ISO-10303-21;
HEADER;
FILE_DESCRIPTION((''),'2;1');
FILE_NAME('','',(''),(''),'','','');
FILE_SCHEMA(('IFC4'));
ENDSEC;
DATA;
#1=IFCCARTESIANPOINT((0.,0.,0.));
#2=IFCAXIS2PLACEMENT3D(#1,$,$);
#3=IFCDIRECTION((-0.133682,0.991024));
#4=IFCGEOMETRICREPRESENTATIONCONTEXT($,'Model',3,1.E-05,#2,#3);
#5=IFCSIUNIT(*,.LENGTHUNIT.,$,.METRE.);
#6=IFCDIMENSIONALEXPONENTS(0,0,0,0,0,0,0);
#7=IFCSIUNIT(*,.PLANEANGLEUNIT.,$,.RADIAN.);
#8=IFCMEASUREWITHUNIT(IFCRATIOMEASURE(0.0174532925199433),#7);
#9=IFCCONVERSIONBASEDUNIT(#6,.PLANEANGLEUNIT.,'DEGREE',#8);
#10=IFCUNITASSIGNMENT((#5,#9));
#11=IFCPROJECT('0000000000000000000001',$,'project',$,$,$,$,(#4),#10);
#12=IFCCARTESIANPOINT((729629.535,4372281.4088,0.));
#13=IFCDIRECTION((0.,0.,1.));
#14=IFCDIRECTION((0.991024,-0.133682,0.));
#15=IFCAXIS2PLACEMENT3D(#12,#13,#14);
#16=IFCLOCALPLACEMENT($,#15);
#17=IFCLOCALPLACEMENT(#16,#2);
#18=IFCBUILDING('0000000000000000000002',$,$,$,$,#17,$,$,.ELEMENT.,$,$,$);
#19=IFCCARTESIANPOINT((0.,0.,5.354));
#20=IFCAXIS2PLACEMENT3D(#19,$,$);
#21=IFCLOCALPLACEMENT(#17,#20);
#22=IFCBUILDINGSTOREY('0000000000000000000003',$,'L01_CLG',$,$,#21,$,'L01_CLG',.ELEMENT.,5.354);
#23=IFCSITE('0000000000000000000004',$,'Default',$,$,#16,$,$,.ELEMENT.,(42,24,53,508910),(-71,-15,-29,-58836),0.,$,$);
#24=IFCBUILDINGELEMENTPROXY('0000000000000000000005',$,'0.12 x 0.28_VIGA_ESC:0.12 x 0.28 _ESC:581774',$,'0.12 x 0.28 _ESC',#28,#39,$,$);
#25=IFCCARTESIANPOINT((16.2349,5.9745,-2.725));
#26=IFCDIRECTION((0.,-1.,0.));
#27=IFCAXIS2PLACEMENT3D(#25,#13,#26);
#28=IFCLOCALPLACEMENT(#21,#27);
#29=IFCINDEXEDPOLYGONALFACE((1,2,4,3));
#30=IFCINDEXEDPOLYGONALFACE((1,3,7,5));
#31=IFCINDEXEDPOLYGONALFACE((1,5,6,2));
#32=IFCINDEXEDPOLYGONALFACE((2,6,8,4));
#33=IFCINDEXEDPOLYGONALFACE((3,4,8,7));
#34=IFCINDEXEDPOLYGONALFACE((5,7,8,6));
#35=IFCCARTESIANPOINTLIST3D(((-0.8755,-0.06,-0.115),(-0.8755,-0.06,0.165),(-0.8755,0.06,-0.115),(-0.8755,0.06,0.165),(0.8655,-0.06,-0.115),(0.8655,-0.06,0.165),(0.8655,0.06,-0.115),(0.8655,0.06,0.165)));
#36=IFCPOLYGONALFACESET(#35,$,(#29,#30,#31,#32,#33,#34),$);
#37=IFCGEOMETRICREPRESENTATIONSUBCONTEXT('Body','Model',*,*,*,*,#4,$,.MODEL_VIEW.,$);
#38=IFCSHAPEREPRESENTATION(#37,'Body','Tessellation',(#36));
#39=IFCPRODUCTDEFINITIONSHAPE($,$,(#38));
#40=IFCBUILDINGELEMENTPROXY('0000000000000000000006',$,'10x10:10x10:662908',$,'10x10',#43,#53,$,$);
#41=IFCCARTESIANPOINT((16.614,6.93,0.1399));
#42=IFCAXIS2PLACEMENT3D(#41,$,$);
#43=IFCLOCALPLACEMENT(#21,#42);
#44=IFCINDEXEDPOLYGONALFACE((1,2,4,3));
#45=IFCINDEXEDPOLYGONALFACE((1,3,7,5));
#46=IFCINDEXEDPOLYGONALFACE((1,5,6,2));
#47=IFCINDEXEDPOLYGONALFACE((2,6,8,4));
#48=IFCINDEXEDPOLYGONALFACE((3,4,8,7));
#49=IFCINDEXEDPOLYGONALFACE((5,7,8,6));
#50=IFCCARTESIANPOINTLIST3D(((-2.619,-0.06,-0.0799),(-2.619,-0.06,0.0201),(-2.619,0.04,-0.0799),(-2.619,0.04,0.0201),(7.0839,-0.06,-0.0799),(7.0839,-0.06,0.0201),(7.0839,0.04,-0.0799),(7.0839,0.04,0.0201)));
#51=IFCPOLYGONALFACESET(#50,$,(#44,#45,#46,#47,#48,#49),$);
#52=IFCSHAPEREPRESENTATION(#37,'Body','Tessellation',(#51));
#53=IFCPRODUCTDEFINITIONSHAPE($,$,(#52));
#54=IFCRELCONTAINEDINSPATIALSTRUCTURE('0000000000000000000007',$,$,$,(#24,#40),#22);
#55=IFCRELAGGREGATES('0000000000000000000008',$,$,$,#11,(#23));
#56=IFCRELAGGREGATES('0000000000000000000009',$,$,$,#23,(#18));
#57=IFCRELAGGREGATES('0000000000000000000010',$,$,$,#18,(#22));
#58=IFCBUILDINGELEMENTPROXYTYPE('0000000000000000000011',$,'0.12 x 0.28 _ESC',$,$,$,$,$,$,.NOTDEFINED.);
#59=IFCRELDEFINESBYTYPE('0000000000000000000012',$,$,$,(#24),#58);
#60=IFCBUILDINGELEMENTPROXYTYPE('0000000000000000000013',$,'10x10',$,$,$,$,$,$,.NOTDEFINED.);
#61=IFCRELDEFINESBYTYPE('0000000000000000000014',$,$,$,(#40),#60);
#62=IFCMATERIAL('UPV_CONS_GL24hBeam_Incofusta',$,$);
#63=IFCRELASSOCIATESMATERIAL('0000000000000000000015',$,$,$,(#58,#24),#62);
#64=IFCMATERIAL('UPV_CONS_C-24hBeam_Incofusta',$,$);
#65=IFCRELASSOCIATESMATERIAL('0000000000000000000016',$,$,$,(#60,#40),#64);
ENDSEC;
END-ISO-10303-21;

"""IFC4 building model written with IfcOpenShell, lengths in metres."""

from ifc_helpers import new_model, entity, si_unit, converted_unit, direction, frame, origin, origin_2d_with_axis, place, context, subcontext, project, spatial, rectangle, extrude, source, transform, mapped, material, type_object, type_shapes, element, save


model = new_model("IFC4")

# Units and contexts
model_context = context("Model", 3, precision=1e-05, world=origin(), true_north=direction((-0.133682, 0.991024)))
body_context = subcontext(model_context, "Body", "Model", "MODEL_VIEW")
ifc_project = project(units=[si_unit("LENGTHUNIT", "METRE"), converted_unit("PLANEANGLEUNIT", "DEGREE", entity("IfcRatioMeasure", 0.0174532925199433), si_unit("PLANEANGLEUNIT", "RADIAN"), dimensions=[0, 0, 0, 0, 0, 0, 0])], contexts=[model_context])

# Site, building, storey
site_placement = place(None, frame((729629.535, 4372281.4088, 0.0), z_axis=(0.0, 0.0, 1.0), x_axis=(0.991024, -0.133682, 0.0)))
site = spatial("IfcSite", under=ifc_project, at=site_placement, Name="Default", CompositionType="ELEMENT", RefLatitude=(42, 24, 53, 508910), RefLongitude=(-71, -15, -29, -58836), RefElevation=0.0)
building_placement = place(site_placement, origin())
building = spatial("IfcBuilding", under=site, at=building_placement, CompositionType="ELEMENT")
storey_placement = place(building_placement, frame((0.0, 0.0, 5.354)))
storey = spatial("IfcBuildingStorey", under=building, at=storey_placement, Name="L01_CLG", LongName="L01_CLG", CompositionType="ELEMENT", Elevation=5.354)

# Building element proxies
ifc_material_1 = material(Name="UPV_CONS_C-24hBeam_Incofusta")
ifc_material_2 = material(Name="UPV_CONS_GL24hBeam_Incofusta")
building_element_proxy_type_1 = type_object("IfcBuildingElementProxyType", Name="0.12 x 0.28 _ESC", material=ifc_material_2)
shared_shape_1 = source(origin(), body_context, "Body", "SweptSolid", [
    extrude(rectangle(XDim=0.12, YDim=1.741, at=origin_2d_with_axis()), frame((-0.005, 0.0, -0.115), z_axis=(0.0, 0.0, 1.0), x_axis=(0.0, 1.0, 0.0)), (0.0, 0.0, 1.0), 0.28),
])
type_shapes(building_element_proxy_type_1, [shared_shape_1])
proxy_1_placement = place(storey_placement, frame((16.2349, 5.9745, -2.725), z_axis=(0.0, 0.0, 1.0), x_axis=(0.0, -1.0, 0.0)))
element("IfcBuildingElementProxy", 1, at=proxy_1_placement, inside=storey, type_object=building_element_proxy_type_1, material=ifc_material_2, Name="0.12 x 0.28_VIGA_ESC:0.12 x 0.28 _ESC:581774", ObjectType="0.12 x 0.28 _ESC", context=body_context, shape_type="MappedRepresentation", body=[
    mapped(shared_shape_1, transform((0.0, 0.0, 0.0), scale=1.0)),
])
building_element_proxy_type_2 = type_object("IfcBuildingElementProxyType", Name="10x10", material=ifc_material_1)
shared_shape_2 = source(origin(), body_context, "Body", "SweptSolid", [
    extrude(rectangle(XDim=0.1, YDim=9.7029, at=origin_2d_with_axis()), frame((2.2325, -0.01, -0.0799), z_axis=(0.0, 0.0, 1.0), x_axis=(0.0, -1.0, 0.0)), (0.0, 0.0, 1.0), 0.1),
])
type_shapes(building_element_proxy_type_2, [shared_shape_2])
proxy_2_placement = place(storey_placement, frame((16.614, 6.93, 0.1399)))
element("IfcBuildingElementProxy", 2, at=proxy_2_placement, inside=storey, type_object=building_element_proxy_type_2, material=ifc_material_1, Name="10x10:10x10:662908", ObjectType="10x10", context=body_context, shape_type="MappedRepresentation", body=[
    mapped(shared_shape_2, transform((0.0, 0.0, 0.0), scale=1.0)),
])

save(model, "model.ifc")
